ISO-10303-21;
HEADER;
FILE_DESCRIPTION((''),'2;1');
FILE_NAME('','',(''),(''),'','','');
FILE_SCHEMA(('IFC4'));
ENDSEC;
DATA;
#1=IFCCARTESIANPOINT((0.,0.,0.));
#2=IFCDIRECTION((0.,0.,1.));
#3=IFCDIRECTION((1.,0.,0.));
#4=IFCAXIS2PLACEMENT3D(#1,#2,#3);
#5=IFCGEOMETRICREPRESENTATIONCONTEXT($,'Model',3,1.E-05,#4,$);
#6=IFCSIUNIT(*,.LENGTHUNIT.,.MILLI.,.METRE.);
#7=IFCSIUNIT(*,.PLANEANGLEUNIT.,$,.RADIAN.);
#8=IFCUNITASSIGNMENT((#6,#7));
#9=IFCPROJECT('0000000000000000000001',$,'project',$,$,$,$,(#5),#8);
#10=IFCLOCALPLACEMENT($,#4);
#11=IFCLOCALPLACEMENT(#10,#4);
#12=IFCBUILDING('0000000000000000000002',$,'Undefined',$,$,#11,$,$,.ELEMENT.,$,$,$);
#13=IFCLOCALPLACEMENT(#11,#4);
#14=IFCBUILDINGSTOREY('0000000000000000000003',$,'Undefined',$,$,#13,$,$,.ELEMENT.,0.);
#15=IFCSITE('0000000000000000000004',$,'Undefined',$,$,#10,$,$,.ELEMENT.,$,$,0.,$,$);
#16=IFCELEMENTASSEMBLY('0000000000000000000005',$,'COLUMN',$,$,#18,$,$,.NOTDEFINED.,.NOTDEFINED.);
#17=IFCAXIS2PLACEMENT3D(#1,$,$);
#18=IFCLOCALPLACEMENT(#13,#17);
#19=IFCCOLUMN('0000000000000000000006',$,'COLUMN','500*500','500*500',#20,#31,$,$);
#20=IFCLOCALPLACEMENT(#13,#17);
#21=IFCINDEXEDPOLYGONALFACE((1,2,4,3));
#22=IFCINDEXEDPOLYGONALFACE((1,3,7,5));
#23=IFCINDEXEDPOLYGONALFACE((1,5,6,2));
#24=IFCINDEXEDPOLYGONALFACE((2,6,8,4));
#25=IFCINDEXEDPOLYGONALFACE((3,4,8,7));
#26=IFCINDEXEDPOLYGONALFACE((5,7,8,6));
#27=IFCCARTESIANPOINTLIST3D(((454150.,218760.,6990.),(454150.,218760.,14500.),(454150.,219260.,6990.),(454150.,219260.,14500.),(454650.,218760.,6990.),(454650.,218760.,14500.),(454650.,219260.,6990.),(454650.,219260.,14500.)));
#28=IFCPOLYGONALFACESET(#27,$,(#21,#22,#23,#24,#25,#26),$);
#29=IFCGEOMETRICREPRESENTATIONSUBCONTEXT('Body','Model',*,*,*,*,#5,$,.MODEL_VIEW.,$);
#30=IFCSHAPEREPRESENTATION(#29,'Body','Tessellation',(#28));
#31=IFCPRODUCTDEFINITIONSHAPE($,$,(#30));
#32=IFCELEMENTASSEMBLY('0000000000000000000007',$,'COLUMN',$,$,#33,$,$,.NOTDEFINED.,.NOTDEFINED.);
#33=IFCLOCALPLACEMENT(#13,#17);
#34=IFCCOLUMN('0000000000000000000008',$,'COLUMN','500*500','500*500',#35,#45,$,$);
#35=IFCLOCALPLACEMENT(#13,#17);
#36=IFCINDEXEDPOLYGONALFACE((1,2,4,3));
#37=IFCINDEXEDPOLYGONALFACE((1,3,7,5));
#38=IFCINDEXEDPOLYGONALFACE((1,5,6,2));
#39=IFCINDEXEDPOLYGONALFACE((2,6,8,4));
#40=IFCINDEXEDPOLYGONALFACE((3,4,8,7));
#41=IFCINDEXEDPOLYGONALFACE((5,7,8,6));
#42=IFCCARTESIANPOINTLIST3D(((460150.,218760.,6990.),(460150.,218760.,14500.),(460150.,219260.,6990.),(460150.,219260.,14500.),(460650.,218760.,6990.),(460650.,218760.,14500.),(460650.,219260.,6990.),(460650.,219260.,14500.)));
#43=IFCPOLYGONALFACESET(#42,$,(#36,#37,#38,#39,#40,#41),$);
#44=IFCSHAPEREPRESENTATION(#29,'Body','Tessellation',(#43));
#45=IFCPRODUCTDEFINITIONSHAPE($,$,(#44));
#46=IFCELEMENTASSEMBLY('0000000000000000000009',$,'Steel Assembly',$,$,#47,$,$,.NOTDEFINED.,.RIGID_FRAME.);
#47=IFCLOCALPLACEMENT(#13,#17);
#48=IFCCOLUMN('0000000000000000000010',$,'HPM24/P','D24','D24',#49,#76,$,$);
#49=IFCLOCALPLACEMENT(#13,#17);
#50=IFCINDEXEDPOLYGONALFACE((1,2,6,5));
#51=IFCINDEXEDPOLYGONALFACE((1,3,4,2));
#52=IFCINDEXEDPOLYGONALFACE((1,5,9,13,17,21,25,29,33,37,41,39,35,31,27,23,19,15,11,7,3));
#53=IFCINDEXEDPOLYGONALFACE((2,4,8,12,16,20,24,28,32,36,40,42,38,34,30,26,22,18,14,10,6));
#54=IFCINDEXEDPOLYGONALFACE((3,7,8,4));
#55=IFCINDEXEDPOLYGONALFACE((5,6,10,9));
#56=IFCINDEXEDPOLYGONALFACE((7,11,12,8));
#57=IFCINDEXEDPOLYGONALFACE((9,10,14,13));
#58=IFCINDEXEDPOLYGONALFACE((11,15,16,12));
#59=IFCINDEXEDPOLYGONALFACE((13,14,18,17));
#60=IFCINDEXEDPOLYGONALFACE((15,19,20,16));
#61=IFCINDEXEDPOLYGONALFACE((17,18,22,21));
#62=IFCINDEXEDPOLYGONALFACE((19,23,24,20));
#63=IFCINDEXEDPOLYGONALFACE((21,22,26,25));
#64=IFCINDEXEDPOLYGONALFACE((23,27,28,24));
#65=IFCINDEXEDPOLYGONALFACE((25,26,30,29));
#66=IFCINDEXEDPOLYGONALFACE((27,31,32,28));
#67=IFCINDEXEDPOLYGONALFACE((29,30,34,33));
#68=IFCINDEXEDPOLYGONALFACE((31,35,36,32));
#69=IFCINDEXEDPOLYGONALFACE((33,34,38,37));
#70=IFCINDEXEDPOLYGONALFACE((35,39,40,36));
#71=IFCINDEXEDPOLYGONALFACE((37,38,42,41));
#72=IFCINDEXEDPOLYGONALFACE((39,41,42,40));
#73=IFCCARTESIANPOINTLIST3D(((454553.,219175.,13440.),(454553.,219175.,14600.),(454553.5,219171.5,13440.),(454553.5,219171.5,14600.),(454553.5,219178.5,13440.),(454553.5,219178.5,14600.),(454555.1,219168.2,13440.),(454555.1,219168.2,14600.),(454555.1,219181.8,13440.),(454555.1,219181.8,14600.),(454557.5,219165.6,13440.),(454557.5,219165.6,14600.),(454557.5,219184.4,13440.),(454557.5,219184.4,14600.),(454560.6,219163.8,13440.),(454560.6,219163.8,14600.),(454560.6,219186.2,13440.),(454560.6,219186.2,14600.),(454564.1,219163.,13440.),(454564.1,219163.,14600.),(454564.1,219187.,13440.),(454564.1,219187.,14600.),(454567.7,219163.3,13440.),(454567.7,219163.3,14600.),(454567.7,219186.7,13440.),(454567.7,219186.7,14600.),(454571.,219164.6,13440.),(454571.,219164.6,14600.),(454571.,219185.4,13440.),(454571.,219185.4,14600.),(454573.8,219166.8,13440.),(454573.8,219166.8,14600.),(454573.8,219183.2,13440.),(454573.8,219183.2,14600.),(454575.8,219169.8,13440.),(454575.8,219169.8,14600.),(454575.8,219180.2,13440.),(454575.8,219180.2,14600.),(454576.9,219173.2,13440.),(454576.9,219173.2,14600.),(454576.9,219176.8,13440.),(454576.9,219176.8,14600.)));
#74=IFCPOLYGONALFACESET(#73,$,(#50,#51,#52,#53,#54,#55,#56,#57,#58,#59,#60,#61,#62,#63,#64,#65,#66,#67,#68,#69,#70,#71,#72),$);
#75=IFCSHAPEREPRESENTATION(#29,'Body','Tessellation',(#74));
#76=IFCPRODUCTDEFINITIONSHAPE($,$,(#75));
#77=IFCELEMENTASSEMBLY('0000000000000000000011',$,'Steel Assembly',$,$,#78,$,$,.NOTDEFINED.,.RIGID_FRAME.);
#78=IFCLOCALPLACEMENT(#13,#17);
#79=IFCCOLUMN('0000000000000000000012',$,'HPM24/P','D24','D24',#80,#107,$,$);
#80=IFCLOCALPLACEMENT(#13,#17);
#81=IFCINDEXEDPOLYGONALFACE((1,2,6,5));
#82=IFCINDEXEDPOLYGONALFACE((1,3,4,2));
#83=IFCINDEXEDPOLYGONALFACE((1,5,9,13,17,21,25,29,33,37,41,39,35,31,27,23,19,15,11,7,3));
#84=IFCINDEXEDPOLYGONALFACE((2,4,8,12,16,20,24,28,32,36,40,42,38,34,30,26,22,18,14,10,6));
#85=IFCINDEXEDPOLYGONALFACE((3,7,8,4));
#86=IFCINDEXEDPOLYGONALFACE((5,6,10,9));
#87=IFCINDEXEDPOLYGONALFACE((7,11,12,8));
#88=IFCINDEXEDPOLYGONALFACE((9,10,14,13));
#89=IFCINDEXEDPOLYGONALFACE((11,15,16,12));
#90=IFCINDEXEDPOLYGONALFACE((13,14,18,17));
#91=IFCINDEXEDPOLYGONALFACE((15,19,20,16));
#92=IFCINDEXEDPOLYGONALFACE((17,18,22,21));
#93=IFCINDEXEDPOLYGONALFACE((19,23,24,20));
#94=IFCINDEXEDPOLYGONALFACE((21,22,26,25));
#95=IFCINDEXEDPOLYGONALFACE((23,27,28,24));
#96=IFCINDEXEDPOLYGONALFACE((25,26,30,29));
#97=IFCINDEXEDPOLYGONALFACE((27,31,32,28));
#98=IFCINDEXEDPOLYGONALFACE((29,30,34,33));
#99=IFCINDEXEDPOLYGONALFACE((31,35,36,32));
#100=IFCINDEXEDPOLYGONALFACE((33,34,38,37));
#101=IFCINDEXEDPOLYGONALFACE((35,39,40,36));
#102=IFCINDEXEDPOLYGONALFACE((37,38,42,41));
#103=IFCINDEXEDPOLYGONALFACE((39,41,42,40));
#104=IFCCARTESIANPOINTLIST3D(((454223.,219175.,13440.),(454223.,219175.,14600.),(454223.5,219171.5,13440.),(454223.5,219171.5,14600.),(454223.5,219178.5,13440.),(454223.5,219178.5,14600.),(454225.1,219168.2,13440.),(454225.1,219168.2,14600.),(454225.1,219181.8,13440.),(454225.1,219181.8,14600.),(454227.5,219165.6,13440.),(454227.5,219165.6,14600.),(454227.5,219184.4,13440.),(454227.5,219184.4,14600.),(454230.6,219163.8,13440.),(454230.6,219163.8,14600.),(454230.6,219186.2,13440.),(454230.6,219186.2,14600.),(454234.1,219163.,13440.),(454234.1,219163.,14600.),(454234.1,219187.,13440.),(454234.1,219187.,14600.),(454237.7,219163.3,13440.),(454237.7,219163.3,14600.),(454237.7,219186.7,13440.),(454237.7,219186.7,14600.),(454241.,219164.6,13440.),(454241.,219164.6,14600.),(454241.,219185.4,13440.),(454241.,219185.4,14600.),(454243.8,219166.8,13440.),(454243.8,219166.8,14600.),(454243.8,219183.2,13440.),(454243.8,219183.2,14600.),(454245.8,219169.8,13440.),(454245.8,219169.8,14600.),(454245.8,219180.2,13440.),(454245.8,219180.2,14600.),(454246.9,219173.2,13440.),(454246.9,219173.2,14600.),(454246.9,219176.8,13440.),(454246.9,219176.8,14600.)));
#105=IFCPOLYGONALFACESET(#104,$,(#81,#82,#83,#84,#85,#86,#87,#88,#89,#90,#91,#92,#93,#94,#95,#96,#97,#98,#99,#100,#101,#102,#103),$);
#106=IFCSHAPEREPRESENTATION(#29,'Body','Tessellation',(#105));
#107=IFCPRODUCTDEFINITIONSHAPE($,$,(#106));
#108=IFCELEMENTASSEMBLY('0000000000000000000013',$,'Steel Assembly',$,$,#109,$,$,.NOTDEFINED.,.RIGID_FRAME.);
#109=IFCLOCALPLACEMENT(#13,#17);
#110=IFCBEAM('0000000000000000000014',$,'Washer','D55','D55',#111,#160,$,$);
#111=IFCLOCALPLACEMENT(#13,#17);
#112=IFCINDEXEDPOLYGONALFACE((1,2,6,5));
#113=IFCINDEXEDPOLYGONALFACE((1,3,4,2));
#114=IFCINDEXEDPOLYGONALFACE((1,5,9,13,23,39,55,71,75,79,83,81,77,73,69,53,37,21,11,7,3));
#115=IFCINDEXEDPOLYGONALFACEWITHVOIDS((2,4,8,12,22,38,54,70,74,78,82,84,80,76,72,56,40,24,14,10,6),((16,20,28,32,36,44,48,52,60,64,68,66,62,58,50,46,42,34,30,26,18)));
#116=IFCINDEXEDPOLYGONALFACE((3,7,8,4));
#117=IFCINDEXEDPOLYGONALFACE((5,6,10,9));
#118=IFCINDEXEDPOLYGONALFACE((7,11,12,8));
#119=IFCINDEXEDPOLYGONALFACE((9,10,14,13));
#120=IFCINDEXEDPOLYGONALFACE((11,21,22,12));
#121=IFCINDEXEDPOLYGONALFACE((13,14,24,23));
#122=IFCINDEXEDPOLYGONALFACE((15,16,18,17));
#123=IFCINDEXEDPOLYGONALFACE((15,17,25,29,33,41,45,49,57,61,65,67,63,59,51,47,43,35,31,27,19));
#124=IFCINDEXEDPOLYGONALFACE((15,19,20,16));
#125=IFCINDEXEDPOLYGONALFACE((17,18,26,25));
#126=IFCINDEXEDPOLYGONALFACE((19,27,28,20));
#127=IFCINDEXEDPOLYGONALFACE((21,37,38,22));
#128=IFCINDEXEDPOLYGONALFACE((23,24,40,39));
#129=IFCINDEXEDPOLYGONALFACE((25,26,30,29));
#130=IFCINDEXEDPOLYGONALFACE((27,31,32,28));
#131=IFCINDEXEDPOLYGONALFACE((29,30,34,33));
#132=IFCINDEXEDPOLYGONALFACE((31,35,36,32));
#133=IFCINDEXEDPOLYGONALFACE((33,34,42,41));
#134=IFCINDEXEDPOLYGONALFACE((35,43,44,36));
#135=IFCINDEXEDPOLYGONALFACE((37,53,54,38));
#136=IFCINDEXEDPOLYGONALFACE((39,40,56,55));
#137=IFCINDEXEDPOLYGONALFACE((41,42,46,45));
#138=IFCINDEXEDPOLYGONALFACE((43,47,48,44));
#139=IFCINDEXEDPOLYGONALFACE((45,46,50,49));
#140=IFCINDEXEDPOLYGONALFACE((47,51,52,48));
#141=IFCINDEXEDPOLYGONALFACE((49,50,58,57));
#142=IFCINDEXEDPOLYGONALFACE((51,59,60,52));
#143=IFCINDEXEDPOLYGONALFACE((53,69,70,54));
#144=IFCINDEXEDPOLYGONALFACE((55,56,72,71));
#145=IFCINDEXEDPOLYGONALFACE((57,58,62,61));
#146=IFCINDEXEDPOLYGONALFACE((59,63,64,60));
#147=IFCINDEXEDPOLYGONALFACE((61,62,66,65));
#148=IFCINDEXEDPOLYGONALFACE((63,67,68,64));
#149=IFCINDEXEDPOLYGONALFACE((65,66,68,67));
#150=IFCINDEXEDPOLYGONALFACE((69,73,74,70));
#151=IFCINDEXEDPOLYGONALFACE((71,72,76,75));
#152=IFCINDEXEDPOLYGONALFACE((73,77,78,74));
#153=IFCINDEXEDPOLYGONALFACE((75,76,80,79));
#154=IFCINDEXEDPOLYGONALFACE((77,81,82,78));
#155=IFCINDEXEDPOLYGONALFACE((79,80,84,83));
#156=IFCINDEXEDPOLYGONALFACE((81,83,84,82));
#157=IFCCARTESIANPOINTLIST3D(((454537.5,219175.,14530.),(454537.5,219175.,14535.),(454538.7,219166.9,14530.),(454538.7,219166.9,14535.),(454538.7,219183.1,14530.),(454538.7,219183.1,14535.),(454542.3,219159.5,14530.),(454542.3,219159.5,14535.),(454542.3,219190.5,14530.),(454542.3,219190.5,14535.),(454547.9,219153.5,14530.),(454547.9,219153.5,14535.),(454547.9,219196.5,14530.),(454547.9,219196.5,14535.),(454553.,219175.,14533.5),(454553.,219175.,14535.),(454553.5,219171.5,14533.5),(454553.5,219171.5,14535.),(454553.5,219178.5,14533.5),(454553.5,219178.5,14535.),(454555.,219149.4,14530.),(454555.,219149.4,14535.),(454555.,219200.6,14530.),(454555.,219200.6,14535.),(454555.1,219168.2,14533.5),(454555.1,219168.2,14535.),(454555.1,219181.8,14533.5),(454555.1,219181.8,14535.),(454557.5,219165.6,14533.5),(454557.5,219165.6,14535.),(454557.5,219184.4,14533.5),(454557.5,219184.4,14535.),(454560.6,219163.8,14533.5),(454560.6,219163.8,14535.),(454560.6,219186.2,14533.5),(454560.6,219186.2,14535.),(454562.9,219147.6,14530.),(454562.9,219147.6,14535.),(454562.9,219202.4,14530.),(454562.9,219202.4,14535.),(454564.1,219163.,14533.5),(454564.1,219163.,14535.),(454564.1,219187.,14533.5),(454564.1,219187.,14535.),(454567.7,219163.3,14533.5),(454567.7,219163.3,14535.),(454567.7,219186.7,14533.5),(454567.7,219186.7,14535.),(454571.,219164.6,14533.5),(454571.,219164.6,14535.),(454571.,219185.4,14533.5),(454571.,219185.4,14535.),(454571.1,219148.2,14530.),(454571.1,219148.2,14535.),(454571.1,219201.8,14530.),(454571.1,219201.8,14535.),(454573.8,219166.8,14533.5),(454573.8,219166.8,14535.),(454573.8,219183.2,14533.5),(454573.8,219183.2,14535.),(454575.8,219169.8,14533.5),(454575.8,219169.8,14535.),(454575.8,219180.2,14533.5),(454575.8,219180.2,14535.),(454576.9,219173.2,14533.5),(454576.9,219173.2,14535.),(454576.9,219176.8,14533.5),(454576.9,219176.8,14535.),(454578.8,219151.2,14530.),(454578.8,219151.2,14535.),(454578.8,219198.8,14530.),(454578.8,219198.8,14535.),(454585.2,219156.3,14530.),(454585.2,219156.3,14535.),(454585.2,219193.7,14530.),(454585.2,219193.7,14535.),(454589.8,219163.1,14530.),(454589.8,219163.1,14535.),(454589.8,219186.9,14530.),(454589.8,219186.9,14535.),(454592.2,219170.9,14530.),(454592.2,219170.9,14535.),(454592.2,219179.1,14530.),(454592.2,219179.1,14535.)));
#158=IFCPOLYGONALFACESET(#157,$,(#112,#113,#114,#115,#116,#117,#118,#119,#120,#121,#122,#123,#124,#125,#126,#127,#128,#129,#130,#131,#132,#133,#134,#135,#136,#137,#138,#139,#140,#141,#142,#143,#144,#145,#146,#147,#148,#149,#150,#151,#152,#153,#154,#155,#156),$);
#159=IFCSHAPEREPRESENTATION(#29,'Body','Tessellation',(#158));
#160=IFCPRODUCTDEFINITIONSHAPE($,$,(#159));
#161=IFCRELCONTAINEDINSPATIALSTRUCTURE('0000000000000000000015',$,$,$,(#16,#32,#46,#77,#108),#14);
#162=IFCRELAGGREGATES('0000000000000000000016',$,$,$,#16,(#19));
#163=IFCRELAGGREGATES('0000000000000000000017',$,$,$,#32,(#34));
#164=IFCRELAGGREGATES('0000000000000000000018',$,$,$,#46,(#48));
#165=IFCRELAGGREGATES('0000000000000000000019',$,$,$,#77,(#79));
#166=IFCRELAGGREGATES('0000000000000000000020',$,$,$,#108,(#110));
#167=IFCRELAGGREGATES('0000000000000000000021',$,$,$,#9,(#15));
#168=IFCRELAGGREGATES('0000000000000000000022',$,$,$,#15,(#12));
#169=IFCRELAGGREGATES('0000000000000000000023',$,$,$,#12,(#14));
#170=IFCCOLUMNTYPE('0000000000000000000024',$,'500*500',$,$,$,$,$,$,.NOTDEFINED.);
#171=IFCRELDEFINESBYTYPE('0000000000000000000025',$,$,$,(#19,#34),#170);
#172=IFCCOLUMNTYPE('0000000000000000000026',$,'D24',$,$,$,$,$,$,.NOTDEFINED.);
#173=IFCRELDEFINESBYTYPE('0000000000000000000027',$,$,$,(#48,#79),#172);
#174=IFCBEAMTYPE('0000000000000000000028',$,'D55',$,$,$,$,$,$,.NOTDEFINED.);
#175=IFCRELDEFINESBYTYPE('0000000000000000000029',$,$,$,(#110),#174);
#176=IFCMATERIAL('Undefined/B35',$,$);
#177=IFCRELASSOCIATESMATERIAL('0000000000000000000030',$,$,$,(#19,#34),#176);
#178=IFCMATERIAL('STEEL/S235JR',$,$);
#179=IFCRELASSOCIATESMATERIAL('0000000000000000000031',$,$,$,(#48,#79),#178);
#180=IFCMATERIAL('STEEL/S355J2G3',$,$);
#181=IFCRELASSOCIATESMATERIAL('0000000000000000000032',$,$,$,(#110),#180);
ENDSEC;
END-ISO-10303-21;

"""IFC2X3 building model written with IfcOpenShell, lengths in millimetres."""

from ifc_helpers import new_model, si_unit, frame, origin_with_axes, origin_2d_with_axis, place, context, subcontext, project, spatial, rectangle, circle, extrude, boolean, material, type_object, element, aggregate, save


model = new_model("IFC2X3")

# Units and contexts
model_context = context("Model", 3, precision=1e-05, world=origin_with_axes())
body_context = subcontext(model_context, "Body", "Model", "MODEL_VIEW")
ifc_project = project(units=[si_unit("LENGTHUNIT", "METRE", prefix="MILLI"), si_unit("PLANEANGLEUNIT", "RADIAN")], contexts=[model_context])

# Site, building, storey
site_placement = place(None, origin_with_axes())
site = spatial("IfcSite", under=ifc_project, at=site_placement, Name="Undefined", CompositionType="ELEMENT", RefElevation=0.0)
building_placement = place(site_placement, origin_with_axes())
building = spatial("IfcBuilding", under=site, at=building_placement, Name="Undefined", CompositionType="ELEMENT")
storey_placement = place(building_placement, origin_with_axes())
storey = spatial("IfcBuildingStorey", under=building, at=storey_placement, Name="Undefined", CompositionType="ELEMENT", Elevation=0.0)

# Element assemblies, columns
assembly_1_placement = place(storey_placement, origin_with_axes())
assembly_1 = element("IfcElementAssembly", 1, at=assembly_1_placement, inside=storey, Name="COLUMN", AssemblyPlace="NOTDEFINED", PredefinedType="NOTDEFINED")
ifc_material_1 = material(Name="Undefined/B35")
column_type_1 = type_object("IfcColumnType", Name="500*500", PredefinedType="NOTDEFINED")
column_1_placement = place(assembly_1_placement, frame((454400.0, 219010.0, 6990.0), z_axis=(0.0, 0.0, 1.0), x_axis=(1.0, 0.0, 0.0)))
column_1 = element("IfcColumn", 2, at=column_1_placement, type_object=column_type_1, material=ifc_material_1, Name="COLUMN", Description="500*500", ObjectType="500*500", context=body_context, shape_type="SweptSolid", body=[
    extrude(rectangle(XDim=500.0, YDim=500.0, at=origin_2d_with_axis()), frame((0.0, 0.0, 7510.0), z_axis=(0.0, 0.0, -1.0), x_axis=(-1.0, 0.0, 0.0)), (0.0, 0.0, 1.0), 7510.0),
])
aggregate(assembly_1, [column_1])
assembly_2_placement = place(storey_placement, origin_with_axes())
assembly_2 = element("IfcElementAssembly", 3, at=assembly_2_placement, inside=storey, Name="COLUMN", AssemblyPlace="NOTDEFINED", PredefinedType="NOTDEFINED")
column_2_placement = place(assembly_2_placement, frame((460400.0, 219010.0, 6990.0), z_axis=(0.0, 0.0, 1.0), x_axis=(1.0, 0.0, 0.0)))
column_2 = element("IfcColumn", 4, at=column_2_placement, type_object=column_type_1, material=ifc_material_1, Name="COLUMN", Description="500*500", ObjectType="500*500", context=body_context, shape_type="SweptSolid", body=[
    extrude(rectangle(XDim=500.0, YDim=500.0, at=origin_2d_with_axis()), frame((0.0, 0.0, 7510.0), z_axis=(0.0, 0.0, -1.0), x_axis=(-1.0, 0.0, 0.0)), (0.0, 0.0, 1.0), 7510.0),
])
aggregate(assembly_2, [column_2])
assembly_3_placement = place(storey_placement, origin_with_axes())
assembly_3 = element("IfcElementAssembly", 5, at=assembly_3_placement, inside=storey, Name="Steel Assembly", AssemblyPlace="NOTDEFINED", PredefinedType="RIGID_FRAME")
ifc_material_2 = material(Name="STEEL/S235JR")
column_type_2 = type_object("IfcColumnType", Name="D24", PredefinedType="NOTDEFINED")
column_3_placement = place(assembly_3_placement, frame((454565.0, 219175.0, 13440.0), z_axis=(0.0, 0.0, 1.0), x_axis=(1.0, 0.0, 0.0)))
column_3 = element("IfcColumn", 6, at=column_3_placement, type_object=column_type_2, material=ifc_material_2, Name="HPM24/P", Description="D24", ObjectType="D24", context=body_context, shape_type="SweptSolid", body=[
    extrude(circle(Radius=12.0, at=origin_2d_with_axis()), frame((0.0, 0.0, 1160.0), z_axis=(0.0, 0.0, -1.0), x_axis=(-1.0, 0.0, 0.0)), (0.0, 0.0, 1.0), 1160.0),
])
aggregate(assembly_3, [column_3])
assembly_4_placement = place(storey_placement, origin_with_axes())
assembly_4 = element("IfcElementAssembly", 7, at=assembly_4_placement, inside=storey, Name="Steel Assembly", AssemblyPlace="NOTDEFINED", PredefinedType="RIGID_FRAME")
column_4_placement = place(assembly_4_placement, frame((454235.0, 219175.0, 13440.0), z_axis=(0.0, 0.0, 1.0), x_axis=(1.0, 0.0, 0.0)))
column_4 = element("IfcColumn", 8, at=column_4_placement, type_object=column_type_2, material=ifc_material_2, Name="HPM24/P", Description="D24", ObjectType="D24", context=body_context, shape_type="SweptSolid", body=[
    extrude(circle(Radius=12.0, at=origin_2d_with_axis()), frame((0.0, 0.0, 1160.0), z_axis=(0.0, 0.0, -1.0), x_axis=(-1.0, 0.0, 0.0)), (0.0, 0.0, 1.0), 1160.0),
])
aggregate(assembly_4, [column_4])

# Element assembly, beam
assembly_5_placement = place(storey_placement, origin_with_axes())
assembly_5 = element("IfcElementAssembly", 9, at=assembly_5_placement, inside=storey, Name="Steel Assembly", AssemblyPlace="NOTDEFINED", PredefinedType="RIGID_FRAME")
ifc_material_3 = material(Name="STEEL/S355J2G3")
beam_type = type_object("IfcBeamType", Name="D55", PredefinedType="NOTDEFINED")
beam_1_placement = place(assembly_5_placement, frame((454565.0, 219175.0, 14535.0), z_axis=(0.0, -1.0, 0.0), x_axis=(0.0, 0.0, -1.0)))
beam_1 = element("IfcBeam", 10, at=beam_1_placement, type_object=beam_type, material=ifc_material_3, Name="Washer", Description="D55", ObjectType="D55", context=body_context, shape_type="CSG", body=[
    boolean("DIFFERENCE", extrude(circle(Radius=27.5, at=origin_2d_with_axis()), frame((5.0, 0.0, 0.0), z_axis=(-1.0, 0.0, 0.0), x_axis=(0.0, -1.0, 0.0)), (0.0, 0.0, 1.0), 5.0), extrude(circle(Radius=12.0, at=origin_2d_with_axis()), frame((1.5, 0.0, 0.0), z_axis=(-1.0, 0.0, 0.0), x_axis=(0.0, -1.0, 0.0)), (0.0, 0.0, 1.0), 10.0)),
])
aggregate(assembly_5, [beam_1])

save(model, "model.ifc")
